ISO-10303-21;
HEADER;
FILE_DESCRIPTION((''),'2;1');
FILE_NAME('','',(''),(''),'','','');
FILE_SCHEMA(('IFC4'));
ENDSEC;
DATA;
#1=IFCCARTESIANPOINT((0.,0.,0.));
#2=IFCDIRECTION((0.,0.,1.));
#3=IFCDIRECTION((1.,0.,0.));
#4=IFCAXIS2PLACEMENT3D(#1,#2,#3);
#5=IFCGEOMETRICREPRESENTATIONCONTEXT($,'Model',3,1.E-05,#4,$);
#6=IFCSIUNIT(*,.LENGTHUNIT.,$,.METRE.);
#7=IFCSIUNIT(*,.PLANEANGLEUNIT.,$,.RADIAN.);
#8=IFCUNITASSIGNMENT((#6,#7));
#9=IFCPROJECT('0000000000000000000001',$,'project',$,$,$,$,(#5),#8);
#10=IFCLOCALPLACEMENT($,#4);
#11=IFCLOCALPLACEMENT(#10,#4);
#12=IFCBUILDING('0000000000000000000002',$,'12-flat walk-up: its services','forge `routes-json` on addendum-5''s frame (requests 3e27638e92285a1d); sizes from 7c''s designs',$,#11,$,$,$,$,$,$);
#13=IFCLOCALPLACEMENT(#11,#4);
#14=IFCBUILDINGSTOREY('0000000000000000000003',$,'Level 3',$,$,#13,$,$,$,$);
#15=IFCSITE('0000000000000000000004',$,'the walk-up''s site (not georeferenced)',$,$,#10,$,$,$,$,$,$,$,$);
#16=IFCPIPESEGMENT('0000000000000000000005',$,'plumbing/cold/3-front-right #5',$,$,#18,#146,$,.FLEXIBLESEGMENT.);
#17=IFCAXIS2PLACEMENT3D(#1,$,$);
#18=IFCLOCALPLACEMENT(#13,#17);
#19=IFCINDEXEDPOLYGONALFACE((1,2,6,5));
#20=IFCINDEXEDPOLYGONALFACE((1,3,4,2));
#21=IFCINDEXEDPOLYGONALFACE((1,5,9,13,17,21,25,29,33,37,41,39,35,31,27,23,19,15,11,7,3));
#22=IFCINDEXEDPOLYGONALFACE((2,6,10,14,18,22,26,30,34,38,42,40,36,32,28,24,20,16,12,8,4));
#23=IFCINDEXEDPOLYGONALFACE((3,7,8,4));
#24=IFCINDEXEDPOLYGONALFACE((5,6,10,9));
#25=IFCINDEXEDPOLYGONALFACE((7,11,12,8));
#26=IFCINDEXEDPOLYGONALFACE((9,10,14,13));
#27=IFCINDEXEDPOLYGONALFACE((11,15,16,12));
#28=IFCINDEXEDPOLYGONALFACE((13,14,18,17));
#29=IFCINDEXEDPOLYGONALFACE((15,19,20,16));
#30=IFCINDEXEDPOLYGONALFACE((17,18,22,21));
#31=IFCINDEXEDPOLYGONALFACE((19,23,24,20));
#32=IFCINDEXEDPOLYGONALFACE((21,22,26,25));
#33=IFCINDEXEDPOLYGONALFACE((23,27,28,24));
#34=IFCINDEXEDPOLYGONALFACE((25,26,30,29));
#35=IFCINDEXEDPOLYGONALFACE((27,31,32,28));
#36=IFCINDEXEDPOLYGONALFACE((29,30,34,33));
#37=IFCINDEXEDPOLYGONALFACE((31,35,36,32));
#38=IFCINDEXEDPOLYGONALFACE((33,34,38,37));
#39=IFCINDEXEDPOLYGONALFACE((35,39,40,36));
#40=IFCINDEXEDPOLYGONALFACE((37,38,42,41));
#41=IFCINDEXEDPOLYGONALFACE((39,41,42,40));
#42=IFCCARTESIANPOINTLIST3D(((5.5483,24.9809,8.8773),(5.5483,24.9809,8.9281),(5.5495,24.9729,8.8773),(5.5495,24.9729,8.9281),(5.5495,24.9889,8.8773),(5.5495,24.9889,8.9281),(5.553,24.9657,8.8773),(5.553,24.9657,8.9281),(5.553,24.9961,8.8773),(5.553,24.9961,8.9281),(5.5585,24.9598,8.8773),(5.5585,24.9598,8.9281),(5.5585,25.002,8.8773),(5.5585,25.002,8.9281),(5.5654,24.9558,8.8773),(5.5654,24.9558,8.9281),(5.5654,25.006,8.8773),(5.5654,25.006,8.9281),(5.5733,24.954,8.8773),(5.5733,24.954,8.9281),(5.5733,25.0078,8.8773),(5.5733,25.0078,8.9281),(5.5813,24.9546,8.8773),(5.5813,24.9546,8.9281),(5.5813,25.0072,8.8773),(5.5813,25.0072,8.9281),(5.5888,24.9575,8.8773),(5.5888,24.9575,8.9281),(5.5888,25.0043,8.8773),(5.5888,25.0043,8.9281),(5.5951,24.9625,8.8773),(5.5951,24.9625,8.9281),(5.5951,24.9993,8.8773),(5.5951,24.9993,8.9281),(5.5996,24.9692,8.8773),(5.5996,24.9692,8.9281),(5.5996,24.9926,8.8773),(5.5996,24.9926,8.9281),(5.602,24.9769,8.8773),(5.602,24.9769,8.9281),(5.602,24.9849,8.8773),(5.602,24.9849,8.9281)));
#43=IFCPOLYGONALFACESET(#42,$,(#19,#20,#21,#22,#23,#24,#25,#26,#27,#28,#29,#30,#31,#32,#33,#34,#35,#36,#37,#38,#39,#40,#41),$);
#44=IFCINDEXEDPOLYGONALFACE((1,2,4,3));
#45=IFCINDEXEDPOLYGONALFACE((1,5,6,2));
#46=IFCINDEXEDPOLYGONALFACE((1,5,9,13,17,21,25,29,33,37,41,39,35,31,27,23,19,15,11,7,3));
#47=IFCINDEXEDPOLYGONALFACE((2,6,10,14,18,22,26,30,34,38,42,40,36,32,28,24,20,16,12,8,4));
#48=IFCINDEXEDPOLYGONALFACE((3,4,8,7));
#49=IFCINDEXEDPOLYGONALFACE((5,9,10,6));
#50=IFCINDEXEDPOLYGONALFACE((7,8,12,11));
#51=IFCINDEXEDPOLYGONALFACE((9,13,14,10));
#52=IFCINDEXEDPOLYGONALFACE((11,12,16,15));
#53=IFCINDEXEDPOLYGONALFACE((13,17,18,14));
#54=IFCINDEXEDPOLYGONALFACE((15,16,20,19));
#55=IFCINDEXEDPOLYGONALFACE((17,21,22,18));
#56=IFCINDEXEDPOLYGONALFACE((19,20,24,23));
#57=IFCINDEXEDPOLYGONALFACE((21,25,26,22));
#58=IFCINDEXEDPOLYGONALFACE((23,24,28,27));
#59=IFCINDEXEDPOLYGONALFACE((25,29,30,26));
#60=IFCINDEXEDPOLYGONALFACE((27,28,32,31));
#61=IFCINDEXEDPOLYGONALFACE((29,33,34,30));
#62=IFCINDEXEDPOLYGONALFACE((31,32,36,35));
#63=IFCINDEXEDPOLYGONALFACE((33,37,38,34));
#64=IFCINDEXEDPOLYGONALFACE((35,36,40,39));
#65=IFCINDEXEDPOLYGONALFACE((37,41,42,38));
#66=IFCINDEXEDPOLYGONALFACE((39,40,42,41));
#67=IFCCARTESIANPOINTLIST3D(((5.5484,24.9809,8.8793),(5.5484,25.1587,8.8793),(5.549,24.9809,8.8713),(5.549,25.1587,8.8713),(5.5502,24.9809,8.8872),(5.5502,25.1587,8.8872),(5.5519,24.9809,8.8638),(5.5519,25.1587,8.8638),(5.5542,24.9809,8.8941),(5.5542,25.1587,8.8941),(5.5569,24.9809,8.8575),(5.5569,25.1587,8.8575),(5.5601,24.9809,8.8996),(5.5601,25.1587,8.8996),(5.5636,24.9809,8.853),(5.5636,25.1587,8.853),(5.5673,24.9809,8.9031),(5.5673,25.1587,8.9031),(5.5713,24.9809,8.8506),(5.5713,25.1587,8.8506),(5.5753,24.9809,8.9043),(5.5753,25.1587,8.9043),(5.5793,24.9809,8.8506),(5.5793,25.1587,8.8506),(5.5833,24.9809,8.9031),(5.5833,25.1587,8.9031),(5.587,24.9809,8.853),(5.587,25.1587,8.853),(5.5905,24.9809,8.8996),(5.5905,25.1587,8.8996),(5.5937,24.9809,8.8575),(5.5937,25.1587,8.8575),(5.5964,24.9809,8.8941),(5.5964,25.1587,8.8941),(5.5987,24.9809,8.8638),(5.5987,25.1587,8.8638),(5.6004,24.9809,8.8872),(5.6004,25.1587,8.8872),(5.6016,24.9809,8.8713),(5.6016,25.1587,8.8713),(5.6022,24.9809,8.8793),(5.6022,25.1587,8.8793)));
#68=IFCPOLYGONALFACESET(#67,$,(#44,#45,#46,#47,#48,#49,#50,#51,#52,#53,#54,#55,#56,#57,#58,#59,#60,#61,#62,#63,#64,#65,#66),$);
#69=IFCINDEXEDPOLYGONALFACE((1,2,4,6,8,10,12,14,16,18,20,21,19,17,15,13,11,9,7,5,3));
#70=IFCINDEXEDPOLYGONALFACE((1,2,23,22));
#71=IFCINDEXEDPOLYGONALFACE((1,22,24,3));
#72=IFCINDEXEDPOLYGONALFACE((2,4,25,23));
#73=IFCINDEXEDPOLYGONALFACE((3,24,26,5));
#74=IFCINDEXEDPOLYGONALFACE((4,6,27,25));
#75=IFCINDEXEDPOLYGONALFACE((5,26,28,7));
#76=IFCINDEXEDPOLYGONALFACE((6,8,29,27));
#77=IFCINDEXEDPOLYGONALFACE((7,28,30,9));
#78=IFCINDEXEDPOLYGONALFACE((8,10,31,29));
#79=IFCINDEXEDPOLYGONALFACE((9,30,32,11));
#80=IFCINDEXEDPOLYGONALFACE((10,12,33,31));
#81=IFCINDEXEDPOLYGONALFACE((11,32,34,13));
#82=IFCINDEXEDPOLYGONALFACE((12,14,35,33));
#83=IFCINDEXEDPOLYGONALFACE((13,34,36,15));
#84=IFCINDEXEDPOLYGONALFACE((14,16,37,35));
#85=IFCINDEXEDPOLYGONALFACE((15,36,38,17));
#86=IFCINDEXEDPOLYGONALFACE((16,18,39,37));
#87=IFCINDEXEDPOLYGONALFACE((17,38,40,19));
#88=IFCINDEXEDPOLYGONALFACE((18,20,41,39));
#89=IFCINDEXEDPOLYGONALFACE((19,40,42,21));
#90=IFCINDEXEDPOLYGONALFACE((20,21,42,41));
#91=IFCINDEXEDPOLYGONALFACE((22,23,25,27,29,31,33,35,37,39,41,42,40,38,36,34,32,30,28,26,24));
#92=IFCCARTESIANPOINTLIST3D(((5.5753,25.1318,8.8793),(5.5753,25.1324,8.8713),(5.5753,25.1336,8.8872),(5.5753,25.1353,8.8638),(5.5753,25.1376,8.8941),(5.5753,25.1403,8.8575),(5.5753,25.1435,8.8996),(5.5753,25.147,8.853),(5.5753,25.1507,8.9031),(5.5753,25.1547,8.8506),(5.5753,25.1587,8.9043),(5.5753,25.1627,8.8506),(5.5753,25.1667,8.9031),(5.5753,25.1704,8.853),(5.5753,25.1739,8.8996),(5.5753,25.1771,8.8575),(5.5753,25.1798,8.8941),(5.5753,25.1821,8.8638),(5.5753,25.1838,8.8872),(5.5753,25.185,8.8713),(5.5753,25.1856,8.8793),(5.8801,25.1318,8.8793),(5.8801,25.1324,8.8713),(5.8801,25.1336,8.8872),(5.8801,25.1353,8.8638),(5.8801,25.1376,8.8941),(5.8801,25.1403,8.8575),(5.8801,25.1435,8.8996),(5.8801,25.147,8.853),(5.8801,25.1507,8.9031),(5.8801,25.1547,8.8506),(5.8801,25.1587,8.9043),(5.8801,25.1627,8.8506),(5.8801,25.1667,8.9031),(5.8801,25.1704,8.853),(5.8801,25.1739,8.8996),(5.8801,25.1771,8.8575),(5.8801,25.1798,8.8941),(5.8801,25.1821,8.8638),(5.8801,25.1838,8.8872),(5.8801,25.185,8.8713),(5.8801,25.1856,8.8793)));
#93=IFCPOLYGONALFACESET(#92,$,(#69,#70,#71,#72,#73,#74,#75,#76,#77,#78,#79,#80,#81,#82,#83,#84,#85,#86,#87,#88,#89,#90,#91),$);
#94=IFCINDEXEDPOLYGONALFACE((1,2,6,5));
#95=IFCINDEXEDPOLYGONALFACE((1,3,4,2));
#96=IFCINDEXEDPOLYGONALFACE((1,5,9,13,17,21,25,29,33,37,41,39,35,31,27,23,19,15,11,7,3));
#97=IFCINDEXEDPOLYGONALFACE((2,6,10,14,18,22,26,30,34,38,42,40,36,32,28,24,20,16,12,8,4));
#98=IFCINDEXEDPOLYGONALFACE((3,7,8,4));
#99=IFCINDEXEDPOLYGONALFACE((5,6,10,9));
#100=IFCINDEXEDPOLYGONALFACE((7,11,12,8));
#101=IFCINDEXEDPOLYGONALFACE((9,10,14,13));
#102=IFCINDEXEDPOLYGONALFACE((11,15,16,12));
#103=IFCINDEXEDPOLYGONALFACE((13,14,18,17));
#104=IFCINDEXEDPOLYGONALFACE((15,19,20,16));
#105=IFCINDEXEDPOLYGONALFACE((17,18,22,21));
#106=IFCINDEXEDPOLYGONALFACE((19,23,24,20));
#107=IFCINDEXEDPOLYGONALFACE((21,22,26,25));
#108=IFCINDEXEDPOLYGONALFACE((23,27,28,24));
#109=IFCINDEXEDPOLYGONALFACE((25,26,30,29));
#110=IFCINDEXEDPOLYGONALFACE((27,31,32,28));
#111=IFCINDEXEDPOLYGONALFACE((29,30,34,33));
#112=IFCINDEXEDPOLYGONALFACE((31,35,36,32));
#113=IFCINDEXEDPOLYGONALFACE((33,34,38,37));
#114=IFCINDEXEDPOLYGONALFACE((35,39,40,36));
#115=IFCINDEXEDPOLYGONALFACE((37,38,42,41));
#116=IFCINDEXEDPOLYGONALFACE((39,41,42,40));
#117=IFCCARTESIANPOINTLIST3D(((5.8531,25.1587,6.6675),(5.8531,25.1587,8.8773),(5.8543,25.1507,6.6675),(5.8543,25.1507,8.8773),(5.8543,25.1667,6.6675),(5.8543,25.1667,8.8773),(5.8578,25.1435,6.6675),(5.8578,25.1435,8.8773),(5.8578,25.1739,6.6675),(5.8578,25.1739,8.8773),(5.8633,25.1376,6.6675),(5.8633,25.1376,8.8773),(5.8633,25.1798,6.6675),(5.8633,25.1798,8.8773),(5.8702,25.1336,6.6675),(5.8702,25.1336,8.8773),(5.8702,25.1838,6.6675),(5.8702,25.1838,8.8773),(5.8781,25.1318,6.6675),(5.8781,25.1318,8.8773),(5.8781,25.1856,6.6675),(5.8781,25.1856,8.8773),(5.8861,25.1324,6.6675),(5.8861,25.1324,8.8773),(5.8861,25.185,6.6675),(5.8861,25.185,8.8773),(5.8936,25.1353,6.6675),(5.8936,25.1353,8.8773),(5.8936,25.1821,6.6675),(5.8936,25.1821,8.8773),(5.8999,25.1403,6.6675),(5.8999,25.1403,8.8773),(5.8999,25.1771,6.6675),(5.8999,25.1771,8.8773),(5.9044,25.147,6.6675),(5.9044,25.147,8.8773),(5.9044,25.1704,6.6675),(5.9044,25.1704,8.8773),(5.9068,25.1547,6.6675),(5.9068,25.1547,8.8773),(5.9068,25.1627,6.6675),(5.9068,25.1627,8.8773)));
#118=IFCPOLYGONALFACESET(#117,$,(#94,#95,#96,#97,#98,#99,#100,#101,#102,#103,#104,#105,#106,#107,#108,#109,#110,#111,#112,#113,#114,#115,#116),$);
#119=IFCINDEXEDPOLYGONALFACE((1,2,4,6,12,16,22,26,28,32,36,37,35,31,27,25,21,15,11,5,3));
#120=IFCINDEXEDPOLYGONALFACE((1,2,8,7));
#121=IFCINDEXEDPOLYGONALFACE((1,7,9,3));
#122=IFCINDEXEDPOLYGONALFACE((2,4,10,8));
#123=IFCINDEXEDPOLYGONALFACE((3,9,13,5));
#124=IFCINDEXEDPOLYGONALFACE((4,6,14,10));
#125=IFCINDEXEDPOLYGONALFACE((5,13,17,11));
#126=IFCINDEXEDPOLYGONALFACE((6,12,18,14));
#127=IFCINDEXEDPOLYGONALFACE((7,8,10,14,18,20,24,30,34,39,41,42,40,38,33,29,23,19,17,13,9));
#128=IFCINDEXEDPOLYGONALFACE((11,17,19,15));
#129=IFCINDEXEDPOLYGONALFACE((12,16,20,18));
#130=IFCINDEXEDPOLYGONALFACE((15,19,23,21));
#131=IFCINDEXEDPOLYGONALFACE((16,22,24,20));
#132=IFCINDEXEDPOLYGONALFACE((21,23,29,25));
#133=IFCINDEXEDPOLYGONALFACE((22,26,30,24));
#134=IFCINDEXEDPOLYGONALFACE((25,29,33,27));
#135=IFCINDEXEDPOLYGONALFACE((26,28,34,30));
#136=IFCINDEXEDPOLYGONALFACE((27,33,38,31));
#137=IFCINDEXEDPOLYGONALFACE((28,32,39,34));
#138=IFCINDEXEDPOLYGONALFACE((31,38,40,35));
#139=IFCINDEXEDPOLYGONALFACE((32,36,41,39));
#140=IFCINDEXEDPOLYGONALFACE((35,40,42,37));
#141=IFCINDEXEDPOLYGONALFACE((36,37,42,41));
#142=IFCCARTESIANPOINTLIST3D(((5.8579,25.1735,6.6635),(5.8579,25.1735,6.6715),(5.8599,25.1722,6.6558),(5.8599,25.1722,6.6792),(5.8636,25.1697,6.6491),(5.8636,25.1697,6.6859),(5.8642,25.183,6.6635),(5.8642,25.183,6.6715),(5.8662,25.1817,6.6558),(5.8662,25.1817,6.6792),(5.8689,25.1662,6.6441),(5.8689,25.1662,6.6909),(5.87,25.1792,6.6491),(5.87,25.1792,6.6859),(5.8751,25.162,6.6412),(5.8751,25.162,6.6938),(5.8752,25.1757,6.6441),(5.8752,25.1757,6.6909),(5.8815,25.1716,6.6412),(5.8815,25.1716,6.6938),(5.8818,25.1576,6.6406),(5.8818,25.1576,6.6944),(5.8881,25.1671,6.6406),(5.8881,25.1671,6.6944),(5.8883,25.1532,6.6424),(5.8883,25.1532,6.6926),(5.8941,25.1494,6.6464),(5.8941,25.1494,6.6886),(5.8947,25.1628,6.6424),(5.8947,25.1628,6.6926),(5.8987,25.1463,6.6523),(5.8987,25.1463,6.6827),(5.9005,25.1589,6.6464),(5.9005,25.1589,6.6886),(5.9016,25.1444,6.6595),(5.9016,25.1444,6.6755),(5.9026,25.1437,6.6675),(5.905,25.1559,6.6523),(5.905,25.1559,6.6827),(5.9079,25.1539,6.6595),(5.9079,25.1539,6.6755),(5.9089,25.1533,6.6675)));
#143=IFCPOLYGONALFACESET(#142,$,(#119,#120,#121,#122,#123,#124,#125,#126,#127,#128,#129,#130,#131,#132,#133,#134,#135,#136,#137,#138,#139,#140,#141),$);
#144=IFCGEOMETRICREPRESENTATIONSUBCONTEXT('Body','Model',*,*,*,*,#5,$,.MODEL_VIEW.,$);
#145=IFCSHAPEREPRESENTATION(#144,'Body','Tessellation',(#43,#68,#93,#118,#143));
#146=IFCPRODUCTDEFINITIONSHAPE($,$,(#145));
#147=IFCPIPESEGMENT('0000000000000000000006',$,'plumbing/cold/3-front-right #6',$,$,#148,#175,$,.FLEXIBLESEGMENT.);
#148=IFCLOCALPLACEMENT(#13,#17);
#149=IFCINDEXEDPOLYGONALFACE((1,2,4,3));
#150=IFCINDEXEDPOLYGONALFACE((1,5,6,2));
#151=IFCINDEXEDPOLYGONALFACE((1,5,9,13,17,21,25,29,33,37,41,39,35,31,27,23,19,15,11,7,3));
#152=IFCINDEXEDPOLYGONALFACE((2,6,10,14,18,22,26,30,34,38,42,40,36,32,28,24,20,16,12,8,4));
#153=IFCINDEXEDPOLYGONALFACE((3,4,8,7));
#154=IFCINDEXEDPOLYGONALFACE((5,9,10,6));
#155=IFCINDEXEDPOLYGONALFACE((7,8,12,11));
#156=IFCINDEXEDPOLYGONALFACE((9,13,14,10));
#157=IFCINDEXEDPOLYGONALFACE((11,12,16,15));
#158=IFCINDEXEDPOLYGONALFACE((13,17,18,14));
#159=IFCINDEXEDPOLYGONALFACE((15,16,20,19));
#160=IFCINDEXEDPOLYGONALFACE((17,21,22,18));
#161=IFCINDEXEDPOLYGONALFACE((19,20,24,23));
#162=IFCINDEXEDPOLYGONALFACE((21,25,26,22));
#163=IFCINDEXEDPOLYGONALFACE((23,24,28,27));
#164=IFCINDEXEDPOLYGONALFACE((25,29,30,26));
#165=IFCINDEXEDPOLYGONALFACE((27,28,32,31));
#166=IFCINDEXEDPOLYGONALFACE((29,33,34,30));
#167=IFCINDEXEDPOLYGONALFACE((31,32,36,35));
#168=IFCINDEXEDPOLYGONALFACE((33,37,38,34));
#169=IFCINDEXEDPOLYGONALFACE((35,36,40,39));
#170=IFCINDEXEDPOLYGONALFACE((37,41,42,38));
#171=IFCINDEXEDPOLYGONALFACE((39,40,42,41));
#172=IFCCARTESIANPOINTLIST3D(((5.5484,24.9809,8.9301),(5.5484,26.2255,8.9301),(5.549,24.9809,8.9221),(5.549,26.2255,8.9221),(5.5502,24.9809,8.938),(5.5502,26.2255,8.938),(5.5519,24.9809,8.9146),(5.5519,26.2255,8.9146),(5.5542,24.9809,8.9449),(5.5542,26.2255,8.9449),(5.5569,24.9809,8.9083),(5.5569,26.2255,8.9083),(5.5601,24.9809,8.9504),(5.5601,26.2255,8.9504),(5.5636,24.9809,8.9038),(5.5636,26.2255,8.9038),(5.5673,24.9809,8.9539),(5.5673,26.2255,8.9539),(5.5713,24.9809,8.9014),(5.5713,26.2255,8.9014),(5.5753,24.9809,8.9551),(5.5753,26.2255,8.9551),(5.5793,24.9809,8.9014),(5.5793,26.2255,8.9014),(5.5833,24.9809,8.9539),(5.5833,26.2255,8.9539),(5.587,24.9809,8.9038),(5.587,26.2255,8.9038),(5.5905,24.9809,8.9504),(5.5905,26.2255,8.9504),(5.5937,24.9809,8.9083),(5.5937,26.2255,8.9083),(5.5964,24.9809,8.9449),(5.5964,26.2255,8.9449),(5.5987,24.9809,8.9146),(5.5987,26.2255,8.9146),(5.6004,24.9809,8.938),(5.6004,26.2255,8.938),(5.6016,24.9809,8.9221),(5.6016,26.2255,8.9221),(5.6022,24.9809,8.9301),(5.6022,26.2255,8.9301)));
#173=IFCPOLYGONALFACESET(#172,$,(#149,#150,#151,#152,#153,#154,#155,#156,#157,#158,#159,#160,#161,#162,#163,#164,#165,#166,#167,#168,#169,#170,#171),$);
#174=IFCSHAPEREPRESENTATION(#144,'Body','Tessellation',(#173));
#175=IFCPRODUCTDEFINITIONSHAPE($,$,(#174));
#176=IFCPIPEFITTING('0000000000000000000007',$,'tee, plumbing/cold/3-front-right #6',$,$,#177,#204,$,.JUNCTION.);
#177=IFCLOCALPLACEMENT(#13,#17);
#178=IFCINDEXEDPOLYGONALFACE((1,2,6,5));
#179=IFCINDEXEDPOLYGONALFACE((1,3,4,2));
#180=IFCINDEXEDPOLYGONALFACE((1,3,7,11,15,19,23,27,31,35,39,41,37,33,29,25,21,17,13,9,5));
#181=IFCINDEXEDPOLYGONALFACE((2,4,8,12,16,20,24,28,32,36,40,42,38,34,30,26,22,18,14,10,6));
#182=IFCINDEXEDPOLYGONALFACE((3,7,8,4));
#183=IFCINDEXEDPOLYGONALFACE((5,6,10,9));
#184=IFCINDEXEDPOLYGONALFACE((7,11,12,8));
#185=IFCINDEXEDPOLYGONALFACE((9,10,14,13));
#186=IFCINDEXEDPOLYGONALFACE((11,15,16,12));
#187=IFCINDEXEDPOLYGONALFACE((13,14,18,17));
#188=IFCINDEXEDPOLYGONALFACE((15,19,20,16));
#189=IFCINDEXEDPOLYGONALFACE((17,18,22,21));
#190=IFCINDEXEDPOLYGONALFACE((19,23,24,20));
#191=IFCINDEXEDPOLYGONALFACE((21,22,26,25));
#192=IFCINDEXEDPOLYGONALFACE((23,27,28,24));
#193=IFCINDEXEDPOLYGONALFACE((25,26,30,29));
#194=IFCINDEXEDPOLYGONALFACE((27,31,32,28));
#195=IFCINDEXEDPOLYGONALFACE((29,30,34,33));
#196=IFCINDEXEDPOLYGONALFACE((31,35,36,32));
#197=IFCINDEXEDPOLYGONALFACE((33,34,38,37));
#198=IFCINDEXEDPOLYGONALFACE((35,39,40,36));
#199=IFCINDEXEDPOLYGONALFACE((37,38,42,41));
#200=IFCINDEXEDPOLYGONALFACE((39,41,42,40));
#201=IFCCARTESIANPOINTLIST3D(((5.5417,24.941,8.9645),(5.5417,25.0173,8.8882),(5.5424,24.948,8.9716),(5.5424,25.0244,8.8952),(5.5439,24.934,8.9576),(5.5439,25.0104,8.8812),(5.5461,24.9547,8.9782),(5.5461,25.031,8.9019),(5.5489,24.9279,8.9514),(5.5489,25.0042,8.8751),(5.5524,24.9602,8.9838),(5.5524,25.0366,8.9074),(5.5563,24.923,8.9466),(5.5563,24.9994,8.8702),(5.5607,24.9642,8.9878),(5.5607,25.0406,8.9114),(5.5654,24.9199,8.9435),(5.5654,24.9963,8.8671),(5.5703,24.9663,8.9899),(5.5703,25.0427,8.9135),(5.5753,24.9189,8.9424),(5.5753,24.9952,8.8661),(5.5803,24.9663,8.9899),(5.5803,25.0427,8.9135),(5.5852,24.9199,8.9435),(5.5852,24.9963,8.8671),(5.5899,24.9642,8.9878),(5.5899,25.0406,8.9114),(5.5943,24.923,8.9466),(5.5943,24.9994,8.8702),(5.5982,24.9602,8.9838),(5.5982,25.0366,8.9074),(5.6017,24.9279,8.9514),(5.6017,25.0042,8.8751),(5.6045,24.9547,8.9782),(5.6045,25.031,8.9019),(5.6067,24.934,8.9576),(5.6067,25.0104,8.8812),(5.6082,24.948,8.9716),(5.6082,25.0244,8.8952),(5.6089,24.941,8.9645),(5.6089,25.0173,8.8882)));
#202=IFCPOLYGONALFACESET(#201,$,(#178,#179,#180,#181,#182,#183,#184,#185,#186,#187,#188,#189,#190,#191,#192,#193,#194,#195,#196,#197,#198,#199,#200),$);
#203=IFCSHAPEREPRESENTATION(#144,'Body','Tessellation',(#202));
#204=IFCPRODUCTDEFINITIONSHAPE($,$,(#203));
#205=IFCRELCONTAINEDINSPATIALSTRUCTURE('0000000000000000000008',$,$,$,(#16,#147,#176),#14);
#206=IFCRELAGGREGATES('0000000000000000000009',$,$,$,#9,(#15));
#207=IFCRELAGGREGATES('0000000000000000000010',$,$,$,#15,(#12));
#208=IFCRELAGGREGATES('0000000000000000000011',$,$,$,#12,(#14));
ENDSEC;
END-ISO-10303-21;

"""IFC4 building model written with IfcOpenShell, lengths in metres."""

from ifc_helpers import new_model, entity, si_unit, frame, origin_with_axes, place, context, subcontext, project, spatial, element, save


model = new_model("IFC4")

# Units and contexts
model_context = context("Model", 3, precision=1e-05, world=origin_with_axes())
body_context = subcontext(model_context, "Body", "Model", "MODEL_VIEW")
ifc_project = project(units=[si_unit("LENGTHUNIT", "METRE"), si_unit("PLANEANGLEUNIT", "RADIAN")], contexts=[model_context])

# Site, building, storey
site_placement = place(None, origin_with_axes())
site = spatial("IfcSite", under=ifc_project, at=site_placement, Name="the walk-up's site (not georeferenced)")
building_placement = place(site_placement, origin_with_axes())
building = spatial("IfcBuilding", under=site, at=building_placement, Name="12-flat walk-up: its services", Description="forge `routes-json` on addendum-5's frame (requests 3e27638e92285a1d); sizes from 7c's designs")
storey_placement = place(building_placement, origin_with_axes())
storey = spatial("IfcBuildingStorey", under=building, at=storey_placement, Name="Level 3")

# Pipe segments
pipe_segment_1_placement = place(storey_placement, frame((5.5753, 24.9809, 8.9281), z_axis=(0.0, 0.0, 1.0), x_axis=(1.0, 0.0, 0.0)))
element("IfcPipeSegment", 1, at=pipe_segment_1_placement, inside=storey, Name="plumbing/cold/3-front-right #5", PredefinedType="FLEXIBLESEGMENT", context=body_context, shape_type="AdvancedSweptSolid", body=[
    entity("IfcSweptDiskSolid", entity("IfcPolyline", [entity("IfcCartesianPoint", [0.0, 0.0, 0.0]), entity("IfcCartesianPoint", [0.0, 0.0, -0.0508])]), 0.027),
    entity("IfcSweptDiskSolid", entity("IfcPolyline", [entity("IfcCartesianPoint", [0.0, 0.0, -0.0508]), entity("IfcCartesianPoint", [0.0, 0.1778, -0.0508])]), 0.027),
    entity("IfcSweptDiskSolid", entity("IfcPolyline", [entity("IfcCartesianPoint", [0.0, 0.1778, -0.0508]), entity("IfcCartesianPoint", [0.3048, 0.1778, -0.0508])]), 0.027),
    entity("IfcSweptDiskSolid", entity("IfcPolyline", [entity("IfcCartesianPoint", [0.3048, 0.1778, -0.0508]), entity("IfcCartesianPoint", [0.3048, 0.1778, -2.2606])]), 0.027),
    entity("IfcSweptDiskSolid", entity("IfcPolyline", [entity("IfcCartesianPoint", [0.3048, 0.1778, -2.2606]), entity("IfcCartesianPoint", [0.3112, 0.1873, -2.2606])]), 0.027),
])
pipe_segment_2_placement = place(storey_placement, frame((5.5753, 24.9809, 8.9281), z_axis=(0.0, 0.0, 1.0), x_axis=(1.0, 0.0, 0.0)))
element("IfcPipeSegment", 2, at=pipe_segment_2_placement, inside=storey, Name="plumbing/cold/3-front-right #6", PredefinedType="FLEXIBLESEGMENT", context=body_context, shape_type="AdvancedSweptSolid", body=[
    entity("IfcSweptDiskSolid", entity("IfcPolyline", [entity("IfcCartesianPoint", [0.0, 0.0, 0.0]), entity("IfcCartesianPoint", [0.0, 1.2446, 0.0])]), 0.027),
])

# Pipe fitting
pipe_fitting_1_placement = place(storey_placement, frame((5.5753, 24.9427, 8.9663), z_axis=(0.0, 0.0, 1.0), x_axis=(1.0, 0.0, 0.0)))
element("IfcPipeFitting", 3, at=pipe_fitting_1_placement, inside=storey, Name="tee, plumbing/cold/3-front-right #6", PredefinedType="JUNCTION", context=body_context, shape_type="AdvancedSweptSolid", body=[
    entity("IfcSweptDiskSolid", entity("IfcPolyline", [entity("IfcCartesianPoint", [0.0, 0.0, 0.0]), entity("IfcCartesianPoint", [0.0, 0.0763, -0.0763])]), 0.0337),
])

save(model, "model.ifc")
